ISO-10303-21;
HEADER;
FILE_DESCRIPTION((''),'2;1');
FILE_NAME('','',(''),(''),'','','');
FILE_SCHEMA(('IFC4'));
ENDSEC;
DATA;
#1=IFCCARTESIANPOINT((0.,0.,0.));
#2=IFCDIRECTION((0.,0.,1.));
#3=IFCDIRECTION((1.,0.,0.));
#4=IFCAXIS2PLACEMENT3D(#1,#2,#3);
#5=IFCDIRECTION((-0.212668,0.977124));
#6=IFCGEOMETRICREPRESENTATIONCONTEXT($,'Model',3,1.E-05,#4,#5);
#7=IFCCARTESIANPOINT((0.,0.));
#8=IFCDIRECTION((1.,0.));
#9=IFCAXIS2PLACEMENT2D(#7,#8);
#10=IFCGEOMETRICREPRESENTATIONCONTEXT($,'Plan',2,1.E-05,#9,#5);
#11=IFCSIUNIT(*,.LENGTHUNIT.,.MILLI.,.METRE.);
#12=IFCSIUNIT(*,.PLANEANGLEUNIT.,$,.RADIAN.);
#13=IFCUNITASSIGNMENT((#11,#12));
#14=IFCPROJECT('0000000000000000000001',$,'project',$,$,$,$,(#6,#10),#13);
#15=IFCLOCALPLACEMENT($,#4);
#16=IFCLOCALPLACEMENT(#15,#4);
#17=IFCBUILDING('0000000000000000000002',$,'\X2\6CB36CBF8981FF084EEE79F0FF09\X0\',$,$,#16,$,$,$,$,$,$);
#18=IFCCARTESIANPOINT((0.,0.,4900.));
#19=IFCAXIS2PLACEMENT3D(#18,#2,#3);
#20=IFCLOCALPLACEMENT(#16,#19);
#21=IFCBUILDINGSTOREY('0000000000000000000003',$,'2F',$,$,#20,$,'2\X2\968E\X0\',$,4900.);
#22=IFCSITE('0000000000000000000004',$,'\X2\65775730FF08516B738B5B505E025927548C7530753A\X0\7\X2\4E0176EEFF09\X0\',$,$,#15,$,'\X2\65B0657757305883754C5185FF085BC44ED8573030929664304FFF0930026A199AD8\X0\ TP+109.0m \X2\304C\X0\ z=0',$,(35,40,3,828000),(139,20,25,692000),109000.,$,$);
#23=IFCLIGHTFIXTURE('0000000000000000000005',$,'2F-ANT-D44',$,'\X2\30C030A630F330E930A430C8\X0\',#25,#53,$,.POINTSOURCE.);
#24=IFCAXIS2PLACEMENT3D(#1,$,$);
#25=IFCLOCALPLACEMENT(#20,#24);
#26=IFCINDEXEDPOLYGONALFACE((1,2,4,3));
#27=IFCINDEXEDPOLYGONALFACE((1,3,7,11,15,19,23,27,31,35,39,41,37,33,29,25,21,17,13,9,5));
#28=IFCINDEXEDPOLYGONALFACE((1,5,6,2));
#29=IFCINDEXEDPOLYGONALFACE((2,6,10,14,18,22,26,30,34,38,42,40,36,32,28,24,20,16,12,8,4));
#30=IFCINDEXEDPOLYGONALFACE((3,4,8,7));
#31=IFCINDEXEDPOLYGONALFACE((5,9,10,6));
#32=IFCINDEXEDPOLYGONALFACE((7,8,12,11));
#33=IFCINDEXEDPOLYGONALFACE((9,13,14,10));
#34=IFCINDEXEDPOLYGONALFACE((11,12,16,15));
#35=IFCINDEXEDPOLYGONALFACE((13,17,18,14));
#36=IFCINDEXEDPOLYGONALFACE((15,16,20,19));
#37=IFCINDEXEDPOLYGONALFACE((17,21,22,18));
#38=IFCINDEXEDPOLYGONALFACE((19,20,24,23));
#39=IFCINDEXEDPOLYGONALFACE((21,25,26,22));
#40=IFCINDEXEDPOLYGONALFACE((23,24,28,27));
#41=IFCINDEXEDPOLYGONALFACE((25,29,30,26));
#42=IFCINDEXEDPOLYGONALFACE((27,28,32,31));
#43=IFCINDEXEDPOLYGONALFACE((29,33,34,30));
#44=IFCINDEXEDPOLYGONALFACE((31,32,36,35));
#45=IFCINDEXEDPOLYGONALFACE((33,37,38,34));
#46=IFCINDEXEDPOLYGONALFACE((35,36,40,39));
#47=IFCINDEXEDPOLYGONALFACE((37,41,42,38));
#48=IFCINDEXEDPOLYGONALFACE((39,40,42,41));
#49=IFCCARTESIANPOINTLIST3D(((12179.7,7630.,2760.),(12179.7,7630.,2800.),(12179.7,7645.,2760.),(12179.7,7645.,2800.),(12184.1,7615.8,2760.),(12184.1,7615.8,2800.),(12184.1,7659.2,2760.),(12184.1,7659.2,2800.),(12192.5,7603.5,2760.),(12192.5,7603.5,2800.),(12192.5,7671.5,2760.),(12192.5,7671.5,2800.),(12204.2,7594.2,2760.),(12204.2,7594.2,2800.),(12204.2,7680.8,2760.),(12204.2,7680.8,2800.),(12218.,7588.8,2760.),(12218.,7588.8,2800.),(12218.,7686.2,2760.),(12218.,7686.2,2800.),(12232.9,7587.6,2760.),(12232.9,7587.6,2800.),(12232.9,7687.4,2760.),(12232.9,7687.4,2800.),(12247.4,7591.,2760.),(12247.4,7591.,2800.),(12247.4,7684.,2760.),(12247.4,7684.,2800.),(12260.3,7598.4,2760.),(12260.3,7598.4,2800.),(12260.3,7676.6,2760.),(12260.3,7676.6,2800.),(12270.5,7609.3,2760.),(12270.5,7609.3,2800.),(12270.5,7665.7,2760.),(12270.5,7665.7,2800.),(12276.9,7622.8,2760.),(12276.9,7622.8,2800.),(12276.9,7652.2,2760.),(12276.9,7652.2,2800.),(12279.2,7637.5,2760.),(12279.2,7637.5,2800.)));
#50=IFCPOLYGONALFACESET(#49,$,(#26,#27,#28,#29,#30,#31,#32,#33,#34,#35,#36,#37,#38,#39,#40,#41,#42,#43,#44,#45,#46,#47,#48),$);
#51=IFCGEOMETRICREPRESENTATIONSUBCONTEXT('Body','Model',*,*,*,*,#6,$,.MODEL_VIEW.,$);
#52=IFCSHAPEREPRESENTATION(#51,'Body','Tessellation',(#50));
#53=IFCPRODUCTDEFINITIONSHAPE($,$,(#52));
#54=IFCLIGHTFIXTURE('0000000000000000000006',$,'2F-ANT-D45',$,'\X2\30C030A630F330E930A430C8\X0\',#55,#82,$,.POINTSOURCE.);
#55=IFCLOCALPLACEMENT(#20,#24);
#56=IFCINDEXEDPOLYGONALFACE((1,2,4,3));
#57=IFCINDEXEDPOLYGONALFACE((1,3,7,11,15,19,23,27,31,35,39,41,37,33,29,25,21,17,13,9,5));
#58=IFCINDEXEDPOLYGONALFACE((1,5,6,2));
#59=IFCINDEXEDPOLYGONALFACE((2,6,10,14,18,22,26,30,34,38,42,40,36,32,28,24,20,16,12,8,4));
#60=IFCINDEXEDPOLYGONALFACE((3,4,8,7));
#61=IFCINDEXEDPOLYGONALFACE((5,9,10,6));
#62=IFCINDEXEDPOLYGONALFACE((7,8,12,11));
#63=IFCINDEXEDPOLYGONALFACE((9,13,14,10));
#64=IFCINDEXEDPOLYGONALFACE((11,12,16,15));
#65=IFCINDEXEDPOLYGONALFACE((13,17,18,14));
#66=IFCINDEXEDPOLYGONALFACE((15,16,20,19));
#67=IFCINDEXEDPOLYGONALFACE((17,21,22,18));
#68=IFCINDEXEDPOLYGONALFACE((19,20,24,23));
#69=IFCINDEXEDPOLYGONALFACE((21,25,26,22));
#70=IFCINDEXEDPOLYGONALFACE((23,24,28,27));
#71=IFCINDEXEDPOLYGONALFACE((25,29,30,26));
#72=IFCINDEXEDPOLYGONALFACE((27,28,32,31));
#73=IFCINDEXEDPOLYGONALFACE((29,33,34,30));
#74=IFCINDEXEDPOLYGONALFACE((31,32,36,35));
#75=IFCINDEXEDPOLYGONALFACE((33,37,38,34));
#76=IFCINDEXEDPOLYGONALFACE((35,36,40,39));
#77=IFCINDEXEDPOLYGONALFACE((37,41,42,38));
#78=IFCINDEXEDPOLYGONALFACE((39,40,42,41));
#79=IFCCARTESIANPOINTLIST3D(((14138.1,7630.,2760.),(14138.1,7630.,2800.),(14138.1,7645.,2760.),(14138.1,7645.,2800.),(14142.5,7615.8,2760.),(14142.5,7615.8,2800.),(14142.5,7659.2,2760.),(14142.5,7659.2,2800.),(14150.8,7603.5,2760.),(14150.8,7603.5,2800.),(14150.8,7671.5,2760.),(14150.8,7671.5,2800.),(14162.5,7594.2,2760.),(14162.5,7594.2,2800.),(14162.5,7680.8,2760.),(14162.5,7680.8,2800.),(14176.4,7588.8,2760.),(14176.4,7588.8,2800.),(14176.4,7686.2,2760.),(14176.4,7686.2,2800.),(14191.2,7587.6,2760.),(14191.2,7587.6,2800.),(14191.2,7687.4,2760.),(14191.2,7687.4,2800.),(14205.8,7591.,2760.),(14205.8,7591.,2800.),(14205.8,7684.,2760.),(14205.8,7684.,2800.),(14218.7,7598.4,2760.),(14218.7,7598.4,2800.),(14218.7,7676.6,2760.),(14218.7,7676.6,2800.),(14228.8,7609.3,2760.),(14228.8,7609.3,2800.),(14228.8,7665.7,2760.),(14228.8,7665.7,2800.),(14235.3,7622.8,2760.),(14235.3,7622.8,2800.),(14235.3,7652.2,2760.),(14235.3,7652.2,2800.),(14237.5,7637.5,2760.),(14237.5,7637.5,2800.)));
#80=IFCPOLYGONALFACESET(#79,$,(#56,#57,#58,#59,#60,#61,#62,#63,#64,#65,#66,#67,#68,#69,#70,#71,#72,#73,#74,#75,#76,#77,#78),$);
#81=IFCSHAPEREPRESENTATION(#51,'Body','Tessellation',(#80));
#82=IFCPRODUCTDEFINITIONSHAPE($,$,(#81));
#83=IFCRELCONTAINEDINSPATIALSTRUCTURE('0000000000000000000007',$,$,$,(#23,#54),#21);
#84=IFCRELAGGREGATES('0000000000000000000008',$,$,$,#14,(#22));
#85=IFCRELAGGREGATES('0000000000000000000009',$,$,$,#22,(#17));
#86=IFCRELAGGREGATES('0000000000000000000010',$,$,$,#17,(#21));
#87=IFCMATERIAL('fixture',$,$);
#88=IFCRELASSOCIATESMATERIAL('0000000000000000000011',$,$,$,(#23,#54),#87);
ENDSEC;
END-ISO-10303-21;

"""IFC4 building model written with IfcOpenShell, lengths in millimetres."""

from ifc_helpers import new_model, si_unit, direction, frame, frame_2d, origin_with_axes, origin_2d_with_axis, place, context, subcontext, project, spatial, circle, extrude, material, element, save


model = new_model("IFC4")

# Units and contexts
model_context = context("Model", 3, precision=1e-05, world=origin_with_axes(), true_north=direction((-0.212668, 0.977124)))
plan_context = context("Plan", 2, precision=1e-05, world=origin_2d_with_axis(), true_north=direction((-0.212668, 0.977124)))
body_context = subcontext(model_context, "Body", "Model", "MODEL_VIEW")
ifc_project = project(units=[si_unit("LENGTHUNIT", "METRE", prefix="MILLI"), si_unit("PLANEANGLEUNIT", "RADIAN")], contexts=[model_context, plan_context])

# Site, building, storey
site_placement = place(None, origin_with_axes())
site = spatial("IfcSite", under=ifc_project, at=site_placement, Name="敷地（八王子市大和田町7丁目）", LongName="新敷地境界内（寄付地を除く）。標高 TP+109.0m が z=0", RefLatitude=(35, 40, 3, 828000), RefLongitude=(139, 20, 25, 692000), RefElevation=109000.0)
building_placement = place(site_placement, origin_with_axes())
building = spatial("IfcBuilding", under=site, at=building_placement, Name="河沿要（仮称）")
storey_placement = place(building_placement, frame((0.0, 0.0, 4900.0), z_axis=(0.0, 0.0, 1.0), x_axis=(1.0, 0.0, 0.0)))
storey = spatial("IfcBuildingStorey", under=building, at=storey_placement, Name="2F", LongName="2階", Elevation=4900.0)

# Light fixtures
ifc_material = material(Name="fixture")
light_fixture_1_placement = place(storey_placement, origin_with_axes())
element("IfcLightFixture", 1, at=light_fixture_1_placement, inside=storey, material=ifc_material, Name="2F-ANT-D44", ObjectType="ダウンライト", PredefinedType="POINTSOURCE", context=body_context, shape_type="SweptSolid", body=[
    extrude(circle(Radius=50.0, at=frame_2d((12229.2, 7637.5))), frame((0.0, 0.0, 2760.0)), (0.0, 0.0, 1.0), 40.0),
])
light_fixture_2_placement = place(storey_placement, origin_with_axes())
element("IfcLightFixture", 2, at=light_fixture_2_placement, inside=storey, material=ifc_material, Name="2F-ANT-D45", ObjectType="ダウンライト", PredefinedType="POINTSOURCE", context=body_context, shape_type="SweptSolid", body=[
    extrude(circle(Radius=50.0, at=frame_2d((14187.5, 7637.5))), frame((0.0, 0.0, 2760.0)), (0.0, 0.0, 1.0), 40.0),
])

save(model, "model.ifc")
